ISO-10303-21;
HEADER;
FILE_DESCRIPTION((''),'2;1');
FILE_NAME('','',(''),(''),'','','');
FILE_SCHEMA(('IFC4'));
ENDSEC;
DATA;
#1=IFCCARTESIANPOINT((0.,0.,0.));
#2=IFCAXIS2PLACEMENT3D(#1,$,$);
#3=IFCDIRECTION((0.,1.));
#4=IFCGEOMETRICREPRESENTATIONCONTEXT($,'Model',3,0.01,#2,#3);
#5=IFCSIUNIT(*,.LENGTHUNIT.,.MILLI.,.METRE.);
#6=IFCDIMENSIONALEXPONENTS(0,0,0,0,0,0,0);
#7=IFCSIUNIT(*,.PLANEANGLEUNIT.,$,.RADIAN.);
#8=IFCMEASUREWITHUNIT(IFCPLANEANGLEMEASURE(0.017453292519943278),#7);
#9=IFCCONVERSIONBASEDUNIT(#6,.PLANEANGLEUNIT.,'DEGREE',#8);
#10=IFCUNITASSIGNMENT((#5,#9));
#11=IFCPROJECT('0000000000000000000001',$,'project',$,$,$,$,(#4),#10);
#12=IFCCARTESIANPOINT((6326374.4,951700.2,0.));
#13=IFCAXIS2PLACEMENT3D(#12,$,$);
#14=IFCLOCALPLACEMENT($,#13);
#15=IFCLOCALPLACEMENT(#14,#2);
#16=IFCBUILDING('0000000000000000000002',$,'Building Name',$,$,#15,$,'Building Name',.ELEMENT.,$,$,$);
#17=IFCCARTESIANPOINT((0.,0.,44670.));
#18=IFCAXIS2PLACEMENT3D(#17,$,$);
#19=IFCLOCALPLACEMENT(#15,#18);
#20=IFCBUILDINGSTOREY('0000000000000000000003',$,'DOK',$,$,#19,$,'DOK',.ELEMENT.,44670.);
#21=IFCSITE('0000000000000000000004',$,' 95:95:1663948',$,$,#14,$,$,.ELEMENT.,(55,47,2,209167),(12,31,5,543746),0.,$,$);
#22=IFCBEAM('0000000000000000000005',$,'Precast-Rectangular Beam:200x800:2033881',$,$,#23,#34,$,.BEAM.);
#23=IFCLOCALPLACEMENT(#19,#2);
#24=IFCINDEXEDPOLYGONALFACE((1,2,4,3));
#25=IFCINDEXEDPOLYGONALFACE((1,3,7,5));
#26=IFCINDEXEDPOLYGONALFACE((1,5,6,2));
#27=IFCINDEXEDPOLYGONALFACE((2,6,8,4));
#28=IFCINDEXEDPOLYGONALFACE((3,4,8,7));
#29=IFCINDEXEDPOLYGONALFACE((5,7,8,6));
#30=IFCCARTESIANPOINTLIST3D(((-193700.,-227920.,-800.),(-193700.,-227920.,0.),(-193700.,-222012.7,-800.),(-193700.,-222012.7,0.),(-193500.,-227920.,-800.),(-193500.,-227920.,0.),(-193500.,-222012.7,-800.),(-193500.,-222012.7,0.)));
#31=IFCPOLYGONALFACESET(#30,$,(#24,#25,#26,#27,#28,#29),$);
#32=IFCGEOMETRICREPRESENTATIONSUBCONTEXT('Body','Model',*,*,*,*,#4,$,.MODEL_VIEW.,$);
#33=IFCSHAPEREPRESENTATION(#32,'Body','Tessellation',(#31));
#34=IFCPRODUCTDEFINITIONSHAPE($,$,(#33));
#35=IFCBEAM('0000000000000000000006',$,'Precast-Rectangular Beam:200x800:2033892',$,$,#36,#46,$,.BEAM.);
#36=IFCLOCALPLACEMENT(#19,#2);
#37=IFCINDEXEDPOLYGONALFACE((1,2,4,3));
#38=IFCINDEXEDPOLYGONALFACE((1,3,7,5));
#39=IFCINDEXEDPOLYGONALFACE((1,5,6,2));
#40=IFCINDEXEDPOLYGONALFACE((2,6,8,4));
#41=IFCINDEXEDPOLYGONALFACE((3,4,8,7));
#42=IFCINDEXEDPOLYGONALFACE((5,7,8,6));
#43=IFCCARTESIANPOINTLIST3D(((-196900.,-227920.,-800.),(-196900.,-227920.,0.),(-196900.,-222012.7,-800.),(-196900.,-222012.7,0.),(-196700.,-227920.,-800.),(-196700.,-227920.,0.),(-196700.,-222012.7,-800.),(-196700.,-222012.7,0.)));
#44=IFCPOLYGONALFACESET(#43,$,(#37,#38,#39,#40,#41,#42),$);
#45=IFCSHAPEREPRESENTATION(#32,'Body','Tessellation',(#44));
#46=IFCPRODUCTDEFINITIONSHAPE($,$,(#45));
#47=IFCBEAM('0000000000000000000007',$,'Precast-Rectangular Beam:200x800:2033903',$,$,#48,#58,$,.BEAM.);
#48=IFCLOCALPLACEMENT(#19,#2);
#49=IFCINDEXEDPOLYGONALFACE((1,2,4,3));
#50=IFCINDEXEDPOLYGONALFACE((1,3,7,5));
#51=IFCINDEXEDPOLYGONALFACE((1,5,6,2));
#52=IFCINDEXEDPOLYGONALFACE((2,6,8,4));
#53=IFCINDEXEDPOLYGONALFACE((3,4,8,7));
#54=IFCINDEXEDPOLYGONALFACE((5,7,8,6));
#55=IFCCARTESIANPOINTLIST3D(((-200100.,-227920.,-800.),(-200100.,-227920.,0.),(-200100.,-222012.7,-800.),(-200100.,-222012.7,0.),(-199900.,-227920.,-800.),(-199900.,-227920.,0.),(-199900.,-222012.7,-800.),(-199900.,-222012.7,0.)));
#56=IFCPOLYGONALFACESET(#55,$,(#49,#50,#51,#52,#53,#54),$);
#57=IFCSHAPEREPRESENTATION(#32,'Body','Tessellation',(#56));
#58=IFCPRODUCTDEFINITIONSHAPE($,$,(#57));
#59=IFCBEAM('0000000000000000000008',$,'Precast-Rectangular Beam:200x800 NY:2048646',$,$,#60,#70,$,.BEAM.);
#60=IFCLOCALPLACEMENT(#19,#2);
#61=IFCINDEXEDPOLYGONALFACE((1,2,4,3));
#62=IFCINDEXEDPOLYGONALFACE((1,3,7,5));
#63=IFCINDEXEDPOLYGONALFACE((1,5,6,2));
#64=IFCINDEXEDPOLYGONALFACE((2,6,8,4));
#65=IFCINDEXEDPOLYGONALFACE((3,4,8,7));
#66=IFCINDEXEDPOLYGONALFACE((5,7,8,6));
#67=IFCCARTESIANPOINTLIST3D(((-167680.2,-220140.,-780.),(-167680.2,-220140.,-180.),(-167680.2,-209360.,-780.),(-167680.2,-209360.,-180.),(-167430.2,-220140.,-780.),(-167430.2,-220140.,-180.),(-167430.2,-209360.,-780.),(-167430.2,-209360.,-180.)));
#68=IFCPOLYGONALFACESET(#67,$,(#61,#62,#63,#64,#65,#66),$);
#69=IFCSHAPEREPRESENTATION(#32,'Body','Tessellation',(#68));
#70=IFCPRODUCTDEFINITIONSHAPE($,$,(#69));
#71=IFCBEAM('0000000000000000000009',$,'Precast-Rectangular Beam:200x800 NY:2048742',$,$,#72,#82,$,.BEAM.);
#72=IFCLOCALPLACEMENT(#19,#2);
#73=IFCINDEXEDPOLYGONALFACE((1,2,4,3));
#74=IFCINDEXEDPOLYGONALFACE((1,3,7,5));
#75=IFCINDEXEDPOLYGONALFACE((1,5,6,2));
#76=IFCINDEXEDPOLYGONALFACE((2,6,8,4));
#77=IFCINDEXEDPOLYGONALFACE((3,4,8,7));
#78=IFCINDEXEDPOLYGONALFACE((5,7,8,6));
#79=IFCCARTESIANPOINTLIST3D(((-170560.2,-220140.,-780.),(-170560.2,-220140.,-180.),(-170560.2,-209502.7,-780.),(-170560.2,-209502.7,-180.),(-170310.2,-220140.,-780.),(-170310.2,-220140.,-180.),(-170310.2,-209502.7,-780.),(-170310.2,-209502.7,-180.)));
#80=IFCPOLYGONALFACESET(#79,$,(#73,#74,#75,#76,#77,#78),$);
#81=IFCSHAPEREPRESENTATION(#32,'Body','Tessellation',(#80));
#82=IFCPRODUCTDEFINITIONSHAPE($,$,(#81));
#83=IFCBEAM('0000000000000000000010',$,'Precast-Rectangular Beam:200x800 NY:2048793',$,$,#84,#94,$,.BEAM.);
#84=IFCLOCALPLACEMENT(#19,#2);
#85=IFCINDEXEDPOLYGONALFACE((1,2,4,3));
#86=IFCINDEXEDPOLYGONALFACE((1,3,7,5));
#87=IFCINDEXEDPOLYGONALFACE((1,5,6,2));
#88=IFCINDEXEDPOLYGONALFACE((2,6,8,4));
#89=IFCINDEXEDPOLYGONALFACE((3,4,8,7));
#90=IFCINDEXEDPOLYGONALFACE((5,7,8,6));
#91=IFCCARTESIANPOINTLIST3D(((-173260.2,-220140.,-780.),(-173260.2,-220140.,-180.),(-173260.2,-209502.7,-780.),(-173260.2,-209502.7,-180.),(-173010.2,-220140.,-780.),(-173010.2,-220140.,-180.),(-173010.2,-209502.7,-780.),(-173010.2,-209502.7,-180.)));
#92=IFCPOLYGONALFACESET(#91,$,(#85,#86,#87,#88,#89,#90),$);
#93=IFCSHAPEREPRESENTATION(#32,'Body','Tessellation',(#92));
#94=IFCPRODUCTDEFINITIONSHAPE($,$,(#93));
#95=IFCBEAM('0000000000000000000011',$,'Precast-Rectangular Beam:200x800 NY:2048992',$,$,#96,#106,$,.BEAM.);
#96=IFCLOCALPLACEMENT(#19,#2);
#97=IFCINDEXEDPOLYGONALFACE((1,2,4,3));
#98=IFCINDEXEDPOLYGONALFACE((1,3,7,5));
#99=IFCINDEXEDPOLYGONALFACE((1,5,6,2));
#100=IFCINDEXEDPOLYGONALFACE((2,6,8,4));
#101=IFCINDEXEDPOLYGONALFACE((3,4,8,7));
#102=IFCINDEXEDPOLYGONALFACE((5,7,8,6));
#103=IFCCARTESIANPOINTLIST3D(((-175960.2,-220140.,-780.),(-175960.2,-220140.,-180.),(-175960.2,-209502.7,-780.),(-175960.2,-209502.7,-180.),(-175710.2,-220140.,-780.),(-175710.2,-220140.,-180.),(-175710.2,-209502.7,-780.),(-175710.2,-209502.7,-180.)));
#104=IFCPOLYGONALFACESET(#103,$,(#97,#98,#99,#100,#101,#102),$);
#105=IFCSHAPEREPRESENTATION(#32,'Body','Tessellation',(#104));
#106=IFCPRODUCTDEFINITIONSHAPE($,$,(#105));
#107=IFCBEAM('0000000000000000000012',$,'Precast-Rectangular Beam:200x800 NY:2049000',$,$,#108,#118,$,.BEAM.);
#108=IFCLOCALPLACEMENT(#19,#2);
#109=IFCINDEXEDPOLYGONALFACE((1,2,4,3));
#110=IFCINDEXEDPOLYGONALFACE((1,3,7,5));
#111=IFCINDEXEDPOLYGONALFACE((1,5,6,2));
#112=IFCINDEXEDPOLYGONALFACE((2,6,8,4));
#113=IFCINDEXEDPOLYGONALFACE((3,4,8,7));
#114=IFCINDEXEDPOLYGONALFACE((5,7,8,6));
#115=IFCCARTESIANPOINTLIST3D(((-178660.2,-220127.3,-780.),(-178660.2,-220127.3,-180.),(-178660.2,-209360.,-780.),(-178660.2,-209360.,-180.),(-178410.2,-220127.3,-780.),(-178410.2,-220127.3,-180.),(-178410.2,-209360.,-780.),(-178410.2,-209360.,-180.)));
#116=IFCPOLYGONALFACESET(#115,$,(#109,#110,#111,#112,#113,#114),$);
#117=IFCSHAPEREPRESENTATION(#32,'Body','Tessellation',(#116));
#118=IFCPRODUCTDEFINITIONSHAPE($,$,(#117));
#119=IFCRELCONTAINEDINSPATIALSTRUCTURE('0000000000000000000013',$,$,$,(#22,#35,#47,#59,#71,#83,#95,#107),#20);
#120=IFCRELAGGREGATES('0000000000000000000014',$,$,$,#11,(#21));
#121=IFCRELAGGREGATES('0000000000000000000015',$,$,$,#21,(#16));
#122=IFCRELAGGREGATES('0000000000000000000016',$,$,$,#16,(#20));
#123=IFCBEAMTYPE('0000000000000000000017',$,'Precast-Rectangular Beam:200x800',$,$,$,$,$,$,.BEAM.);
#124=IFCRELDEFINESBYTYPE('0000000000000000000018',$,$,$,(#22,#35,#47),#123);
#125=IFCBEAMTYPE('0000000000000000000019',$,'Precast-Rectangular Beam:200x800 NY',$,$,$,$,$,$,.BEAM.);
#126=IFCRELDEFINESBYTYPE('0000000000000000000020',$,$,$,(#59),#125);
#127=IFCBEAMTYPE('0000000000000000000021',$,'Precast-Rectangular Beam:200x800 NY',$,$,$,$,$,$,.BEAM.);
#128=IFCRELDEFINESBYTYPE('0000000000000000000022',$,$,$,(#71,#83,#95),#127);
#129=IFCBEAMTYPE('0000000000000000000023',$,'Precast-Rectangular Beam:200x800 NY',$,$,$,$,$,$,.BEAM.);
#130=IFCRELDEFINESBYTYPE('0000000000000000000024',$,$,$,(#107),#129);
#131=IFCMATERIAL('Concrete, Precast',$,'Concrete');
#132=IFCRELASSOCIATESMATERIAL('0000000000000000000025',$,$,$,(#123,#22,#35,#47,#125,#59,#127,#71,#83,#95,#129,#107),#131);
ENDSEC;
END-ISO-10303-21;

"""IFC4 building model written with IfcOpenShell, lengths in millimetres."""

from ifc_helpers import new_model, entity, si_unit, converted_unit, direction, frame, origin, place, context, subcontext, project, spatial, indexed_curve, outline, extrude, source, transform, mapped, material, type_object, type_shapes, element, save


model = new_model("IFC4")

# Units and contexts
model_context = context("Model", 3, precision=0.01, world=origin(), true_north=direction((0.0, 1.0)))
body_context = subcontext(model_context, "Body", "Model", "MODEL_VIEW")
ifc_project = project(units=[si_unit("LENGTHUNIT", "METRE", prefix="MILLI"), converted_unit("PLANEANGLEUNIT", "DEGREE", entity("IfcPlaneAngleMeasure", 0.017453292519943278), si_unit("PLANEANGLEUNIT", "RADIAN"), dimensions=[0, 0, 0, 0, 0, 0, 0])], contexts=[model_context])

# Site, building, storey
site_placement = place(None, frame((6326374.4, 951700.2, 0.0)))
site = spatial("IfcSite", under=ifc_project, at=site_placement, Name=" 95:95:1663948", CompositionType="ELEMENT", RefLatitude=(55, 47, 2, 209167), RefLongitude=(12, 31, 5, 543746), RefElevation=0.0)
building_placement = place(site_placement, origin())
building = spatial("IfcBuilding", under=site, at=building_placement, Name="Building Name", LongName="Building Name", CompositionType="ELEMENT")
storey_placement = place(building_placement, frame((0.0, 0.0, 44670.0)))
storey = spatial("IfcBuildingStorey", under=building, at=storey_placement, Name="DOK", LongName="DOK", CompositionType="ELEMENT", Elevation=44670.0)

# Beams
ifc_material_1 = material(Name="Concrete, Precast", Category="Concrete")
beam_type_1 = type_object("IfcBeamType", Name="Precast-Rectangular Beam:200x800", PredefinedType="BEAM", material=ifc_material_1)
shared_shape_1 = source(origin(), body_context, "Body", "SweptSolid", [
    extrude(outline(indexed_curve([(-2953.7, -100.0), (2953.7, -100.0), (2953.7, 100.0), (-2953.7, 100.0), (-2953.7, -100.0)], self_intersect=False)), frame((-66.4, 0.0, -400.0), z_axis=(0.0, 0.0, 1.0), x_axis=(-1.0, 0.0, 0.0)), (0.0, 0.0, 1.0), 800.0),
])
type_shapes(beam_type_1, [shared_shape_1])
for number, where, z_axis, x_axis, name in (
    (1, (-193600.0, -224900.0, -400.0), (0.0, 0.0, 1.0), (0.0, 1.0, 0.0), "Precast-Rectangular Beam:200x800:2033881"),
    (2, (-196800.0, -224900.0, -400.0), (0.0, 0.0, 1.0), (0.0, 1.0, 0.0), "Precast-Rectangular Beam:200x800:2033892"),
    (3, (-200000.0, -224900.0, -400.0), (0.0, 0.0, 1.0), (0.0, 1.0, 0.0), "Precast-Rectangular Beam:200x800:2033903"),
):
    element("IfcBeam", number, at=place(storey_placement, frame(where, z_axis=z_axis, x_axis=x_axis)), inside=storey, type_object=beam_type_1, material=ifc_material_1, Name=name, PredefinedType="BEAM", context=body_context, shape_type="MappedRepresentation", body=[
        mapped(shared_shape_1, transform((0.0, 0.0, 0.0), scale=1.0)),
    ])
beam_type_2 = type_object("IfcBeamType", Name="Precast-Rectangular Beam:200x800 NY", PredefinedType="BEAM", material=ifc_material_1)
shared_shape_2 = source(origin(), body_context, "Body", "SweptSolid", [
    extrude(outline(indexed_curve([(-5390.0, -125.0), (5390.0, -125.0), (5390.0, 125.0), (-5390.0, 125.0), (-5390.0, -125.0)], self_intersect=False)), frame((30.0, 0.0, -300.0), z_axis=(0.0, 0.0, 1.0), x_axis=(-1.0, 0.0, 0.0)), (0.0, 0.0, 1.0), 600.0),
])
type_shapes(beam_type_2, [shared_shape_2])
beam_1_placement = place(storey_placement, frame((-167555.2, -214780.0, -480.0), z_axis=(0.0, 0.0, 1.0), x_axis=(0.0, 1.0, 0.0)))
element("IfcBeam", 4, at=beam_1_placement, inside=storey, type_object=beam_type_2, material=ifc_material_1, Name="Precast-Rectangular Beam:200x800 NY:2048646", PredefinedType="BEAM", context=body_context, shape_type="MappedRepresentation", body=[
    mapped(shared_shape_2, transform((0.0, 0.0, 0.0), scale=1.0)),
])
beam_type_3 = type_object("IfcBeamType", Name="Precast-Rectangular Beam:200x800 NY", PredefinedType="BEAM", material=ifc_material_1)
shared_shape_3 = source(origin(), body_context, "Body", "SweptSolid", [
    extrude(outline(indexed_curve([(-5318.7, -125.0), (5318.7, -125.0), (5318.7, 125.0), (-5318.7, 125.0), (-5318.7, -125.0)], self_intersect=False)), frame((-36.4, 0.0, -300.0), z_axis=(0.0, 0.0, 1.0), x_axis=(-1.0, 0.0, 0.0)), (0.0, 0.0, 1.0), 600.0),
])
type_shapes(beam_type_3, [shared_shape_3])
for number, where, z_axis, x_axis, name in (
    (5, (-170435.2, -214785.0, -480.0), (0.0, 0.0, 1.0), (0.0, 1.0, 0.0), "Precast-Rectangular Beam:200x800 NY:2048742"),
    (6, (-173135.2, -214785.0, -480.0), (0.0, 0.0, 1.0), (0.0, 1.0, 0.0), "Precast-Rectangular Beam:200x800 NY:2048793"),
    (7, (-175835.2, -214785.0, -480.0), (0.0, 0.0, 1.0), (0.0, 1.0, 0.0), "Precast-Rectangular Beam:200x800 NY:2048992"),
):
    element("IfcBeam", number, at=place(storey_placement, frame(where, z_axis=z_axis, x_axis=x_axis)), inside=storey, type_object=beam_type_3, material=ifc_material_1, Name=name, PredefinedType="BEAM", context=body_context, shape_type="MappedRepresentation", body=[
        mapped(shared_shape_3, transform((0.0, 0.0, 0.0), scale=1.0)),
    ])
beam_type_4 = type_object("IfcBeamType", Name="Precast-Rectangular Beam:200x800 NY", PredefinedType="BEAM", material=ifc_material_1)
shared_shape_4 = source(origin(), body_context, "Body", "SweptSolid", [
    extrude(outline(indexed_curve([(-5383.6, -125.0), (5383.6, -125.0), (5383.6, 125.0), (-5383.6, 125.0), (-5383.6, -125.0)], self_intersect=False)), frame((36.4, 0.0, -300.0), z_axis=(0.0, 0.0, 1.0), x_axis=(-1.0, 0.0, 0.0)), (0.0, 0.0, 1.0), 600.0),
])
type_shapes(beam_type_4, [shared_shape_4])
beam_2_placement = place(storey_placement, frame((-178535.2, -214780.0, -480.0), z_axis=(0.0, 0.0, 1.0), x_axis=(0.0, 1.0, 0.0)))
element("IfcBeam", 8, at=beam_2_placement, inside=storey, type_object=beam_type_4, material=ifc_material_1, Name="Precast-Rectangular Beam:200x800 NY:2049000", PredefinedType="BEAM", context=body_context, shape_type="MappedRepresentation", body=[
    mapped(shared_shape_4, transform((0.0, 0.0, 0.0), scale=1.0)),
])

save(model, "model.ifc")
